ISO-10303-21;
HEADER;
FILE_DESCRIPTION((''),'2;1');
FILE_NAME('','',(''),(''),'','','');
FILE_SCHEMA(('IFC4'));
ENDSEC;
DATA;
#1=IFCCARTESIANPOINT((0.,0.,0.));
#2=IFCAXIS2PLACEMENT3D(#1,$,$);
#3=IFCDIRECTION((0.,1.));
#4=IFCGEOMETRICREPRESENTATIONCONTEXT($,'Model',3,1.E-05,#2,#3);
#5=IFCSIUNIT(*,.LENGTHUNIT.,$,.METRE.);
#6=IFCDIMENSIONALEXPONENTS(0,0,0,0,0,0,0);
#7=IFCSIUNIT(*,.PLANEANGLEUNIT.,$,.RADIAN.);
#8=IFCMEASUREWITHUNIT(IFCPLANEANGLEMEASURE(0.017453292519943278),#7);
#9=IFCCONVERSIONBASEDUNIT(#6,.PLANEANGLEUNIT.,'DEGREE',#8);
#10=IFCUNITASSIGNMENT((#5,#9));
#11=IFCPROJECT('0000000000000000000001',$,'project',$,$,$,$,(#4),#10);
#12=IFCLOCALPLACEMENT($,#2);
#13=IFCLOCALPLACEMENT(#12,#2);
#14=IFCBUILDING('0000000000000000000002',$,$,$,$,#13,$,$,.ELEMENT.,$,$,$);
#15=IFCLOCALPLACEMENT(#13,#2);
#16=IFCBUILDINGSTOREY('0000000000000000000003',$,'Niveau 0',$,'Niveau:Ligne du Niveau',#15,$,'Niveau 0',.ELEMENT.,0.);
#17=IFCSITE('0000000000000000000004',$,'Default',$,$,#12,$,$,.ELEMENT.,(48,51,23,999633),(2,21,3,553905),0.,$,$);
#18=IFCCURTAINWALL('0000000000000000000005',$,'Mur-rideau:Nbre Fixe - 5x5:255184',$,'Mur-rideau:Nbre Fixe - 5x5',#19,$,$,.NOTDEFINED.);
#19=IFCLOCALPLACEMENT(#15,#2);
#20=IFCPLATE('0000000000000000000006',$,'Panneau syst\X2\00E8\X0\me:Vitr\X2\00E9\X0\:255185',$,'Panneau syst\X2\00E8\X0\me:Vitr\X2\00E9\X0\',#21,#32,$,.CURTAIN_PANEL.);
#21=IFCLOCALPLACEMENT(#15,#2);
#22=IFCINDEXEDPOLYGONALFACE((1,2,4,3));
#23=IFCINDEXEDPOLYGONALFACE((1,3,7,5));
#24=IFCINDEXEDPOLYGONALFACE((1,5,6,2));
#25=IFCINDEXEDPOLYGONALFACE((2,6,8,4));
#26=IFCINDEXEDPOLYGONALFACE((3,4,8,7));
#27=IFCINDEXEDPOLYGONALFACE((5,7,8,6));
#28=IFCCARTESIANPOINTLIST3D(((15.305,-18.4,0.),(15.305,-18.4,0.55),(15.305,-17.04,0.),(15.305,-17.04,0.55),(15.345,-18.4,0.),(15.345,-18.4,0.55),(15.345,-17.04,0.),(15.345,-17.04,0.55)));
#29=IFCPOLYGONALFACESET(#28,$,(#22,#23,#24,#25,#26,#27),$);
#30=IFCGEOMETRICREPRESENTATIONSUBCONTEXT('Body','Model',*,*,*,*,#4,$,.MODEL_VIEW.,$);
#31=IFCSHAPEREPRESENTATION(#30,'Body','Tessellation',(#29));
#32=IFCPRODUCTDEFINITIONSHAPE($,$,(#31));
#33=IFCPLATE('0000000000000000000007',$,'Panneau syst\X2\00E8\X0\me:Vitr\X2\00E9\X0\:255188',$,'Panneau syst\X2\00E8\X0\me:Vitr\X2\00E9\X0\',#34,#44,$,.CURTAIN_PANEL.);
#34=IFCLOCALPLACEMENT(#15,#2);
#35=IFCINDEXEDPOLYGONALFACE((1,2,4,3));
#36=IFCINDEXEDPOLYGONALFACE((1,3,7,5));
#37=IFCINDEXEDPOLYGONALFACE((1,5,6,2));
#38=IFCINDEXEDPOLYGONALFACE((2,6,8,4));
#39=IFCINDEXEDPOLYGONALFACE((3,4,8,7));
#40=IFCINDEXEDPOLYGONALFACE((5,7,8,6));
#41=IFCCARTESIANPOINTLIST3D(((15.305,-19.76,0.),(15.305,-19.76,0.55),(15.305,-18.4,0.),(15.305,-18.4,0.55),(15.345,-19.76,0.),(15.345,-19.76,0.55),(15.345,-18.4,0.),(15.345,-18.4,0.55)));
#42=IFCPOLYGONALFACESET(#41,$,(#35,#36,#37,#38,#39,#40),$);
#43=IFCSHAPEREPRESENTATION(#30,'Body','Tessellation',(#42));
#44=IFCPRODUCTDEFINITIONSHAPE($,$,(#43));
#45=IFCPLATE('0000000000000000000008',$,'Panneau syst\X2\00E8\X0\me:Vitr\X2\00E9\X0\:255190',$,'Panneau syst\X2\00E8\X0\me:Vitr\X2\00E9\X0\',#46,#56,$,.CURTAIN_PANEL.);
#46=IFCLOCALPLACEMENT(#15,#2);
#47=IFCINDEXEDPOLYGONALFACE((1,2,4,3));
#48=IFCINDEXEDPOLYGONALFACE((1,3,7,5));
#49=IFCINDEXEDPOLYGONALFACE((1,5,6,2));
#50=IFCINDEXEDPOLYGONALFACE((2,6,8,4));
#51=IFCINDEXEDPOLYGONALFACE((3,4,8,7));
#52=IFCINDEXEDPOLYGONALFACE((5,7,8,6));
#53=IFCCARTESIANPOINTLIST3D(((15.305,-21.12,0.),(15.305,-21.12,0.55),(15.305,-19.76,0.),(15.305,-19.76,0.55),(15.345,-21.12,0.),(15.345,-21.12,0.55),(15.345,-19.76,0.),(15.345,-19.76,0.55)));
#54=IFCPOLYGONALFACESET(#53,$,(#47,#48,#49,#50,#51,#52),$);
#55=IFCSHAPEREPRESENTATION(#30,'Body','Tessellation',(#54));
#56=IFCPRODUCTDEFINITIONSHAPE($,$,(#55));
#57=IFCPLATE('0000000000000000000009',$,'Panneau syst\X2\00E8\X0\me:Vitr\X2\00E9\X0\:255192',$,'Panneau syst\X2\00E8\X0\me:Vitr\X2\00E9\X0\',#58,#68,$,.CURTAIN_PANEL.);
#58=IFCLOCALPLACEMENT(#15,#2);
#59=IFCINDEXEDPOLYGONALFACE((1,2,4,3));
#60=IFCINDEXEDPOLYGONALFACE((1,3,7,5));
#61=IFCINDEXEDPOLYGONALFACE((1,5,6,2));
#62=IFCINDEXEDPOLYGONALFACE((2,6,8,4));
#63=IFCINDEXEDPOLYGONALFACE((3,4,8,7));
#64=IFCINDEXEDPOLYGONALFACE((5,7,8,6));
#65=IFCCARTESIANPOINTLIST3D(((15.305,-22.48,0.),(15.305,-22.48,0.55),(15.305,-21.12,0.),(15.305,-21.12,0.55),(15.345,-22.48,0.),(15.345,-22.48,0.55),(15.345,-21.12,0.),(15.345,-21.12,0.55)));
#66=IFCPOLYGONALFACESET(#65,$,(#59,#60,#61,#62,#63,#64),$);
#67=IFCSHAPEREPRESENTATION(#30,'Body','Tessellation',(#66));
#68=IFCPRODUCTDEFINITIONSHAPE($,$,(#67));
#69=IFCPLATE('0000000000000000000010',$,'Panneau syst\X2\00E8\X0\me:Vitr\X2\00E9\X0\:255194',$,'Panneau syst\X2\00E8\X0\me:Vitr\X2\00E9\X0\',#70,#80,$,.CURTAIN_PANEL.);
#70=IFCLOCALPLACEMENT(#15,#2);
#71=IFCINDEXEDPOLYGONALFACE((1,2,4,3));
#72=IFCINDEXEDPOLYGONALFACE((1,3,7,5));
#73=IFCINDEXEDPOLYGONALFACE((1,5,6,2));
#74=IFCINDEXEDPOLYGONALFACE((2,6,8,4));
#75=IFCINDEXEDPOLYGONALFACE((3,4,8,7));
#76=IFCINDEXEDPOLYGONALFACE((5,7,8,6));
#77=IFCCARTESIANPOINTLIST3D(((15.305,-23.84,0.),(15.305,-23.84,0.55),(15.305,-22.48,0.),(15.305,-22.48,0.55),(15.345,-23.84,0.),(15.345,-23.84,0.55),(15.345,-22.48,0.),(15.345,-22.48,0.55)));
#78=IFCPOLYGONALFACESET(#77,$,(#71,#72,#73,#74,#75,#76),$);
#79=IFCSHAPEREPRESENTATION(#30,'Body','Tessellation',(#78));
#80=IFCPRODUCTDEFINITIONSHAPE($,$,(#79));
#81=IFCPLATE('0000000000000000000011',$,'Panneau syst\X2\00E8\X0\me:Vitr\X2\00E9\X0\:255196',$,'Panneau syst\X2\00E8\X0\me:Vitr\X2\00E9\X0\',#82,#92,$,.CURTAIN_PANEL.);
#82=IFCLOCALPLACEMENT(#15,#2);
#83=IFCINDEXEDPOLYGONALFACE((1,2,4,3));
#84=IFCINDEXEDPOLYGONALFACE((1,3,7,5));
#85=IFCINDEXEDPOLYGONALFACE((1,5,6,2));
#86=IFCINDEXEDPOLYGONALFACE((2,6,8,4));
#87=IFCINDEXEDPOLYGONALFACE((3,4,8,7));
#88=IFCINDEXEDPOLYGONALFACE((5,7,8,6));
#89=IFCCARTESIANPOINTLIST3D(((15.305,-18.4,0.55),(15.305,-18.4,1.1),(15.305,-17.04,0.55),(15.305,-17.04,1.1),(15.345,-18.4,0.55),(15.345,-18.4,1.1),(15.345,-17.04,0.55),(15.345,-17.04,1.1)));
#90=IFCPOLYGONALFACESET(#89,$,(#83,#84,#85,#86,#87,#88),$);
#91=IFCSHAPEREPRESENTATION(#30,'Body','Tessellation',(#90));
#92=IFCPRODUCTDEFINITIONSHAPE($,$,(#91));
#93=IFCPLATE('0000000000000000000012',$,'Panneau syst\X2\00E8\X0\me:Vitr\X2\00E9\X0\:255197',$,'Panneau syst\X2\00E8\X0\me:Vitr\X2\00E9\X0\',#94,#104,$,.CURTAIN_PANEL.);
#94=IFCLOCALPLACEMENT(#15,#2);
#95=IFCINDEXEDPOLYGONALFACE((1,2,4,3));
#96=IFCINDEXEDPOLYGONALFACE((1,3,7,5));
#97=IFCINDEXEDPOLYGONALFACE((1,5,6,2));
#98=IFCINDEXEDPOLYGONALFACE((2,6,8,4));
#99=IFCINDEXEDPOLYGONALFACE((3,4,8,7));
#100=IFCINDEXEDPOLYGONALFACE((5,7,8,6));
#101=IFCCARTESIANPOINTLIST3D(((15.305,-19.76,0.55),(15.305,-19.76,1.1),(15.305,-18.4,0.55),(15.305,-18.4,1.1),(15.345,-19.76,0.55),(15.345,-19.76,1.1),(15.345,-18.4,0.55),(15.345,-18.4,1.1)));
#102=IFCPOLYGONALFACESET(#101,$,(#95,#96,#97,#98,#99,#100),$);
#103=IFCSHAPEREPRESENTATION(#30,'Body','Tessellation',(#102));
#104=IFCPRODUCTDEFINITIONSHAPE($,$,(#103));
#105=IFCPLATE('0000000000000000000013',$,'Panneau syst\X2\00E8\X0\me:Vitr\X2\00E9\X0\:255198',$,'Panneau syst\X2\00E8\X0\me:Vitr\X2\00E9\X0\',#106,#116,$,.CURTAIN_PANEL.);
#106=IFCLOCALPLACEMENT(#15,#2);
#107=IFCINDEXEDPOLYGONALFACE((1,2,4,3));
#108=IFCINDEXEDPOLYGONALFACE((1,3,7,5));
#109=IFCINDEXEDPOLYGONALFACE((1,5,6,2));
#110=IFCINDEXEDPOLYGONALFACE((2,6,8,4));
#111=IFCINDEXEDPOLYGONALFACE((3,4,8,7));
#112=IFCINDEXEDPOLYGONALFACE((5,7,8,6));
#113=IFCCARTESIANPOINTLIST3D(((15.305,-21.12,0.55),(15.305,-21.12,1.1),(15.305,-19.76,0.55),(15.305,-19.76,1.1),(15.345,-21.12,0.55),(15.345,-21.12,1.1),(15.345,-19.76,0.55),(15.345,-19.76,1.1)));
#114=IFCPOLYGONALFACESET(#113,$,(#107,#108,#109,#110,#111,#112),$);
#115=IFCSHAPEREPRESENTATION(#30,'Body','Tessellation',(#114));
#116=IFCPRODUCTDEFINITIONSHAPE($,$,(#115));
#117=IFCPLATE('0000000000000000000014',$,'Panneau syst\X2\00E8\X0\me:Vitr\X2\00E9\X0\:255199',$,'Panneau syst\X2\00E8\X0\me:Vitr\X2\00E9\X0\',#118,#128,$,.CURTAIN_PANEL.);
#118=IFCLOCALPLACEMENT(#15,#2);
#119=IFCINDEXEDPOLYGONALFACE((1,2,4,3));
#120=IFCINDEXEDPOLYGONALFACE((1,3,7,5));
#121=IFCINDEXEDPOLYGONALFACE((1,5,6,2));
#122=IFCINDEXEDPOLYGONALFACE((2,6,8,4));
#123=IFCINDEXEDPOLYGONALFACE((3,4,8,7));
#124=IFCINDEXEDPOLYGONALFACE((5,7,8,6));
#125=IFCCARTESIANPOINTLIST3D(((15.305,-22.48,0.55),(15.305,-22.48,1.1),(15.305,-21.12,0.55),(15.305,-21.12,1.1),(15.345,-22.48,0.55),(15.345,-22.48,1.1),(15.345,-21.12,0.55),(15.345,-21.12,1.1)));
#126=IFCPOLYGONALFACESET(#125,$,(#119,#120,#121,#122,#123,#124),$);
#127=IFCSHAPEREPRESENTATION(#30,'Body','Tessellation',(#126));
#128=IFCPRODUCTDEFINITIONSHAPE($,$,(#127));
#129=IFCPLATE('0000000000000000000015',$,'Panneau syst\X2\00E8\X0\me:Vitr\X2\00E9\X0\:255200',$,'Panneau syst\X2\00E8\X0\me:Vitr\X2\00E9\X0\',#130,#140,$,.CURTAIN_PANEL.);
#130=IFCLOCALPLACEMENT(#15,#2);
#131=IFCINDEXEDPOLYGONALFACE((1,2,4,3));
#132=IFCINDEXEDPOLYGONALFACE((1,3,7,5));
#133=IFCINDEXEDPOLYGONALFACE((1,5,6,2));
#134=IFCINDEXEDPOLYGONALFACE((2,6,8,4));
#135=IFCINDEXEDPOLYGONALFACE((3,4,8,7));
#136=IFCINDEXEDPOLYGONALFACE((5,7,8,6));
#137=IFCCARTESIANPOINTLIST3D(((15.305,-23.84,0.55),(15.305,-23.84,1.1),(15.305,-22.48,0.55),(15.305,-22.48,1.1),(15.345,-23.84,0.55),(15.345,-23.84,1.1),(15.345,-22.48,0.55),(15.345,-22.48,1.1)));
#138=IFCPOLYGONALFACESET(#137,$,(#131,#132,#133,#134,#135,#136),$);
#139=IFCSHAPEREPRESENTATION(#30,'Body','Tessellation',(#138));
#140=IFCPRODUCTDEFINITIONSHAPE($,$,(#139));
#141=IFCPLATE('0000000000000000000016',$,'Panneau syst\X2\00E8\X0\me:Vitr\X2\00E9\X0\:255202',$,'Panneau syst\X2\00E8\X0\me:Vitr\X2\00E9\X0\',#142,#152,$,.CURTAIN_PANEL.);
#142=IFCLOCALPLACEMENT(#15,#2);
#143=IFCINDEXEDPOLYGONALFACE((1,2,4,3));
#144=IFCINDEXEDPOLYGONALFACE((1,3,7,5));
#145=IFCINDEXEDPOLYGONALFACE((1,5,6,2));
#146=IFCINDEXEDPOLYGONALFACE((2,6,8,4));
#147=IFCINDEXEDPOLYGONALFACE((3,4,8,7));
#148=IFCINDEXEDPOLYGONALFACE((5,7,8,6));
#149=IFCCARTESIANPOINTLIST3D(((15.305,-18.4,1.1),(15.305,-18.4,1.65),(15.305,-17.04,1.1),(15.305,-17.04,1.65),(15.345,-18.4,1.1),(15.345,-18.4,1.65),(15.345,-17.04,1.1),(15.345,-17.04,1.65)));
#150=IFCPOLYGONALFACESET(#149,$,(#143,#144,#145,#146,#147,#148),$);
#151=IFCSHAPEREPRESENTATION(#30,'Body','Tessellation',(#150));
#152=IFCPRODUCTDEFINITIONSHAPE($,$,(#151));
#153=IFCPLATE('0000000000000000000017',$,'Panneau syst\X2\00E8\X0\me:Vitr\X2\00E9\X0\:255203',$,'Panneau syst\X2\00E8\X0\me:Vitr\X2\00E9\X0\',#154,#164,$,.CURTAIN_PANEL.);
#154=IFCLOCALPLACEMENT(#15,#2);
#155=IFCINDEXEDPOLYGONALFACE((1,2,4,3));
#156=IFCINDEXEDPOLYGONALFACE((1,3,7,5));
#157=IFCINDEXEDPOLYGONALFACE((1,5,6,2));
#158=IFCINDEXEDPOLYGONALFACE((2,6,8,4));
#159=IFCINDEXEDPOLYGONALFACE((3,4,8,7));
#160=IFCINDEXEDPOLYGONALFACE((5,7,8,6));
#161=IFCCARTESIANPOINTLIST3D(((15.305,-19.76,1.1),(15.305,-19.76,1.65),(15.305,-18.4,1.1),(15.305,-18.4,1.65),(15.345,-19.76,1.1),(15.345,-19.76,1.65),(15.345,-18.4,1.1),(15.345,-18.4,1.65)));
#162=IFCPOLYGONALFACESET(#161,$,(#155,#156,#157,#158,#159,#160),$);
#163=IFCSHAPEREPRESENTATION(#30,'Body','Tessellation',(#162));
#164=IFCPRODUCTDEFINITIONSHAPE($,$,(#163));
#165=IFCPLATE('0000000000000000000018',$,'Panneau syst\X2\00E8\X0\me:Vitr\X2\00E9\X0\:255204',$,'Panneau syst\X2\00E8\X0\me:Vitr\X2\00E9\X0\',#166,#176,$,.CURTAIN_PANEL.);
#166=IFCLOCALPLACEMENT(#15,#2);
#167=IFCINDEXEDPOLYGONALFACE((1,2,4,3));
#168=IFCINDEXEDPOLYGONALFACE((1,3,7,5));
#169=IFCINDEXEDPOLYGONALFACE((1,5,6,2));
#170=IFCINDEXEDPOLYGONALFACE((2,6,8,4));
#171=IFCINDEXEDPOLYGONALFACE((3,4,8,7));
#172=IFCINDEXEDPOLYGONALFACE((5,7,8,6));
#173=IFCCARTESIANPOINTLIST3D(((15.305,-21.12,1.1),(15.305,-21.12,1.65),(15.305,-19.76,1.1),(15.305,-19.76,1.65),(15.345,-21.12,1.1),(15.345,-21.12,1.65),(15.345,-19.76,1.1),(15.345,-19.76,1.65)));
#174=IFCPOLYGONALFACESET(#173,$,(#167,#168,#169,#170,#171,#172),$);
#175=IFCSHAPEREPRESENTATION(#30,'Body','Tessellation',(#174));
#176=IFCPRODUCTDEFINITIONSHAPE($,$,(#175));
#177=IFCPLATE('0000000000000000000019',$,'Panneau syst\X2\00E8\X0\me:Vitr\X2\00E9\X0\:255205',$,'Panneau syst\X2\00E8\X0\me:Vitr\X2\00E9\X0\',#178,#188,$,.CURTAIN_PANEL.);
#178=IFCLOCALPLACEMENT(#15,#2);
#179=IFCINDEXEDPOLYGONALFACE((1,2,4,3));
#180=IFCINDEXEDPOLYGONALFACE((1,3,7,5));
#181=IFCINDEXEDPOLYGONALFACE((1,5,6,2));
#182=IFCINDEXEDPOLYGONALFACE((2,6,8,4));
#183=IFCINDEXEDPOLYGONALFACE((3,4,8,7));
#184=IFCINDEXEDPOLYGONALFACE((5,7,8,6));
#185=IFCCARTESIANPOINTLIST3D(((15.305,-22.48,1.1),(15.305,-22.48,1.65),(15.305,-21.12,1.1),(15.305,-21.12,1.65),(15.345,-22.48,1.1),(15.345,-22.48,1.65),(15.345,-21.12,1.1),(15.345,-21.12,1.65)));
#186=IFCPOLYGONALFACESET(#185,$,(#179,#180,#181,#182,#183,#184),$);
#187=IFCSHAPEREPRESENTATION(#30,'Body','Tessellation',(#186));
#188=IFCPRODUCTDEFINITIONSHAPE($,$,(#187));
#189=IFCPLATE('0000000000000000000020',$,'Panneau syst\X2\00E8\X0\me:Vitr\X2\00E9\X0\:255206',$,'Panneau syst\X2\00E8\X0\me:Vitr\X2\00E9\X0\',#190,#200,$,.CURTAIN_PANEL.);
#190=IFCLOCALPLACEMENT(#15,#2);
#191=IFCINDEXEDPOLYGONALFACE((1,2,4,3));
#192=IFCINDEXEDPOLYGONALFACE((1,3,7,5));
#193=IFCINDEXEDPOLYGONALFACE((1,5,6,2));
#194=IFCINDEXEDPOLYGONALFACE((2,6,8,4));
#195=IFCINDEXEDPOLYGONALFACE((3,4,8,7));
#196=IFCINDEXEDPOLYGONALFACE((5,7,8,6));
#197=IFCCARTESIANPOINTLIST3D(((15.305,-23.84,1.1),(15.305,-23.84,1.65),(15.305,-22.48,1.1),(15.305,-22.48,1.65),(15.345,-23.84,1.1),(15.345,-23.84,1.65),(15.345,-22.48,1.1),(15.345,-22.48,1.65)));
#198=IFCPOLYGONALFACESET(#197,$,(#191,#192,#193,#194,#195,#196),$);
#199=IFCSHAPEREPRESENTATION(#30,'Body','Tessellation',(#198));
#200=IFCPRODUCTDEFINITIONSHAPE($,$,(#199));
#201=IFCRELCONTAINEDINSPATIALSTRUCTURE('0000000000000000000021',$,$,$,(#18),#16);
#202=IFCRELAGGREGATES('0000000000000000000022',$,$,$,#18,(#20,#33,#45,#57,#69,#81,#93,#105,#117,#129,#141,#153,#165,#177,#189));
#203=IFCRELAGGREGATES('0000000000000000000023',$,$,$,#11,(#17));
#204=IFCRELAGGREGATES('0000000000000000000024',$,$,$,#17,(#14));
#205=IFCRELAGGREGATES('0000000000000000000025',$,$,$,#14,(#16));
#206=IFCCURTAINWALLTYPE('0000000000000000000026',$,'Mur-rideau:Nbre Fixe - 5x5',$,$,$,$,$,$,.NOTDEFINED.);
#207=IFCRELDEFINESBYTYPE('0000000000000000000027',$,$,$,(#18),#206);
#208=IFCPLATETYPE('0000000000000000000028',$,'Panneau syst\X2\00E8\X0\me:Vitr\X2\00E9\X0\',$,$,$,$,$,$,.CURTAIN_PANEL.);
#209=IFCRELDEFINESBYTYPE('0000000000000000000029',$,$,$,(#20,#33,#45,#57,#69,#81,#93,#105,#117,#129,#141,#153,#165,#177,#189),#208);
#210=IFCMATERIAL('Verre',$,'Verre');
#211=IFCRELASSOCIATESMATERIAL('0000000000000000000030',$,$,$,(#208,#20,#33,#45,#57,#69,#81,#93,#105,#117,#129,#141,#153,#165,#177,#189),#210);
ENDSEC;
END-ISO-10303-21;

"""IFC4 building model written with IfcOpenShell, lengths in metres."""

from ifc_helpers import new_model, entity, si_unit, converted_unit, direction, frame, origin, place, context, subcontext, project, spatial, indexed_curve, outline, extrude, source, transform, mapped, material, type_object, type_shapes, element, aggregate, save


model = new_model("IFC4")

# Units and contexts
model_context = context("Model", 3, precision=1e-05, world=origin(), true_north=direction((0.0, 1.0)))
body_context = subcontext(model_context, "Body", "Model", "MODEL_VIEW")
ifc_project = project(units=[si_unit("LENGTHUNIT", "METRE"), converted_unit("PLANEANGLEUNIT", "DEGREE", entity("IfcPlaneAngleMeasure", 0.017453292519943278), si_unit("PLANEANGLEUNIT", "RADIAN"), dimensions=[0, 0, 0, 0, 0, 0, 0])], contexts=[model_context])

# Site, building, storey
site_placement = place(None, origin())
site = spatial("IfcSite", under=ifc_project, at=site_placement, Name="Default", CompositionType="ELEMENT", RefLatitude=(48, 51, 23, 999633), RefLongitude=(2, 21, 3, 553905), RefElevation=0.0)
building_placement = place(site_placement, origin())
building = spatial("IfcBuilding", under=site, at=building_placement, CompositionType="ELEMENT")
storey_placement = place(building_placement, origin())
storey = spatial("IfcBuildingStorey", under=building, at=storey_placement, Name="Niveau 0", ObjectType="Niveau:Ligne du Niveau", LongName="Niveau 0", CompositionType="ELEMENT", Elevation=0.0)

# Curtain wall, plates
curtain_wall_type = type_object("IfcCurtainWallType", Name="Mur-rideau:Nbre Fixe - 5x5", PredefinedType="NOTDEFINED")
curtain_wall_placement = place(storey_placement, origin())
curtain_wall = element("IfcCurtainWall", 1, at=curtain_wall_placement, inside=storey, type_object=curtain_wall_type, Name="Mur-rideau:Nbre Fixe - 5x5:255184", ObjectType="Mur-rideau:Nbre Fixe - 5x5", PredefinedType="NOTDEFINED")
ifc_material = material(Name="Verre", Category="Verre")
plate_type = type_object("IfcPlateType", Name="Panneau système:Vitré", PredefinedType="CURTAIN_PANEL", material=ifc_material)
shared_shape = source(origin(), body_context, "Body", "SweptSolid", [
    extrude(outline(indexed_curve([(-0.02, -0.68), (0.02, -0.68), (0.02, 0.68), (-0.02, 0.68), (-0.02, -0.68)], self_intersect=False)), frame((0.68, 0.02, 0.0), z_axis=(0.0, 0.0, 1.0), x_axis=(0.0, 1.0, 0.0)), (0.0, 0.0, 1.0), 0.55),
])
type_shapes(plate_type, [shared_shape])
plate_1_placement = place(curtain_wall_placement, frame((15.305, -17.04, 0.0), z_axis=(0.0, 0.0, 1.0), x_axis=(0.0, -1.0, 0.0)))
plate_1 = element("IfcPlate", 2, at=plate_1_placement, type_object=plate_type, material=ifc_material, Name="Panneau système:Vitré:255185", ObjectType="Panneau système:Vitré", PredefinedType="CURTAIN_PANEL", context=body_context, shape_type="MappedRepresentation", body=[
    mapped(shared_shape, transform((0.0, 0.0, 0.0), scale=1.0)),
])
plate_2_placement = place(curtain_wall_placement, frame((15.305, -18.4, 0.0), z_axis=(0.0, 0.0, 1.0), x_axis=(0.0, -1.0, 0.0)))
plate_2 = element("IfcPlate", 3, at=plate_2_placement, type_object=plate_type, material=ifc_material, Name="Panneau système:Vitré:255188", ObjectType="Panneau système:Vitré", PredefinedType="CURTAIN_PANEL", context=body_context, shape_type="MappedRepresentation", body=[
    mapped(shared_shape, transform((0.0, 0.0, 0.0), scale=1.0)),
])
plate_3_placement = place(curtain_wall_placement, frame((15.305, -19.76, 0.0), z_axis=(0.0, 0.0, 1.0), x_axis=(0.0, -1.0, 0.0)))
plate_3 = element("IfcPlate", 4, at=plate_3_placement, type_object=plate_type, material=ifc_material, Name="Panneau système:Vitré:255190", ObjectType="Panneau système:Vitré", PredefinedType="CURTAIN_PANEL", context=body_context, shape_type="MappedRepresentation", body=[
    mapped(shared_shape, transform((0.0, 0.0, 0.0), scale=1.0)),
])
plate_4_placement = place(curtain_wall_placement, frame((15.305, -21.12, 0.0), z_axis=(0.0, 0.0, 1.0), x_axis=(0.0, -1.0, 0.0)))
plate_4 = element("IfcPlate", 5, at=plate_4_placement, type_object=plate_type, material=ifc_material, Name="Panneau système:Vitré:255192", ObjectType="Panneau système:Vitré", PredefinedType="CURTAIN_PANEL", context=body_context, shape_type="MappedRepresentation", body=[
    mapped(shared_shape, transform((0.0, 0.0, 0.0), scale=1.0)),
])
plate_5_placement = place(curtain_wall_placement, frame((15.305, -22.48, 0.0), z_axis=(0.0, 0.0, 1.0), x_axis=(0.0, -1.0, 0.0)))
plate_5 = element("IfcPlate", 6, at=plate_5_placement, type_object=plate_type, material=ifc_material, Name="Panneau système:Vitré:255194", ObjectType="Panneau système:Vitré", PredefinedType="CURTAIN_PANEL", context=body_context, shape_type="MappedRepresentation", body=[
    mapped(shared_shape, transform((0.0, 0.0, 0.0), scale=1.0)),
])
plate_6_placement = place(curtain_wall_placement, frame((15.305, -17.04, 0.55), z_axis=(0.0, 0.0, 1.0), x_axis=(0.0, -1.0, 0.0)))
plate_6 = element("IfcPlate", 7, at=plate_6_placement, type_object=plate_type, material=ifc_material, Name="Panneau système:Vitré:255196", ObjectType="Panneau système:Vitré", PredefinedType="CURTAIN_PANEL", context=body_context, shape_type="MappedRepresentation", body=[
    mapped(shared_shape, transform((0.0, 0.0, 0.0), scale=1.0)),
])
plate_7_placement = place(curtain_wall_placement, frame((15.305, -18.4, 0.55), z_axis=(0.0, 0.0, 1.0), x_axis=(0.0, -1.0, 0.0)))
plate_7 = element("IfcPlate", 8, at=plate_7_placement, type_object=plate_type, material=ifc_material, Name="Panneau système:Vitré:255197", ObjectType="Panneau système:Vitré", PredefinedType="CURTAIN_PANEL", context=body_context, shape_type="MappedRepresentation", body=[
    mapped(shared_shape, transform((0.0, 0.0, 0.0), scale=1.0)),
])
plate_8_placement = place(curtain_wall_placement, frame((15.305, -19.76, 0.55), z_axis=(0.0, 0.0, 1.0), x_axis=(0.0, -1.0, 0.0)))
plate_8 = element("IfcPlate", 9, at=plate_8_placement, type_object=plate_type, material=ifc_material, Name="Panneau système:Vitré:255198", ObjectType="Panneau système:Vitré", PredefinedType="CURTAIN_PANEL", context=body_context, shape_type="MappedRepresentation", body=[
    mapped(shared_shape, transform((0.0, 0.0, 0.0), scale=1.0)),
])
plate_9_placement = place(curtain_wall_placement, frame((15.305, -21.12, 0.55), z_axis=(0.0, 0.0, 1.0), x_axis=(0.0, -1.0, 0.0)))
plate_9 = element("IfcPlate", 10, at=plate_9_placement, type_object=plate_type, material=ifc_material, Name="Panneau système:Vitré:255199", ObjectType="Panneau système:Vitré", PredefinedType="CURTAIN_PANEL", context=body_context, shape_type="MappedRepresentation", body=[
    mapped(shared_shape, transform((0.0, 0.0, 0.0), scale=1.0)),
])
plate_10_placement = place(curtain_wall_placement, frame((15.305, -22.48, 0.55), z_axis=(0.0, 0.0, 1.0), x_axis=(0.0, -1.0, 0.0)))
plate_10 = element("IfcPlate", 11, at=plate_10_placement, type_object=plate_type, material=ifc_material, Name="Panneau système:Vitré:255200", ObjectType="Panneau système:Vitré", PredefinedType="CURTAIN_PANEL", context=body_context, shape_type="MappedRepresentation", body=[
    mapped(shared_shape, transform((0.0, 0.0, 0.0), scale=1.0)),
])
plate_11_placement = place(curtain_wall_placement, frame((15.305, -17.04, 1.1), z_axis=(0.0, 0.0, 1.0), x_axis=(0.0, -1.0, 0.0)))
plate_11 = element("IfcPlate", 12, at=plate_11_placement, type_object=plate_type, material=ifc_material, Name="Panneau système:Vitré:255202", ObjectType="Panneau système:Vitré", PredefinedType="CURTAIN_PANEL", context=body_context, shape_type="MappedRepresentation", body=[
    mapped(shared_shape, transform((0.0, 0.0, 0.0), scale=1.0)),
])
plate_12_placement = place(curtain_wall_placement, frame((15.305, -18.4, 1.1), z_axis=(0.0, 0.0, 1.0), x_axis=(0.0, -1.0, 0.0)))
plate_12 = element("IfcPlate", 13, at=plate_12_placement, type_object=plate_type, material=ifc_material, Name="Panneau système:Vitré:255203", ObjectType="Panneau système:Vitré", PredefinedType="CURTAIN_PANEL", context=body_context, shape_type="MappedRepresentation", body=[
    mapped(shared_shape, transform((0.0, 0.0, 0.0), scale=1.0)),
])
plate_13_placement = place(curtain_wall_placement, frame((15.305, -19.76, 1.1), z_axis=(0.0, 0.0, 1.0), x_axis=(0.0, -1.0, 0.0)))
plate_13 = element("IfcPlate", 14, at=plate_13_placement, type_object=plate_type, material=ifc_material, Name="Panneau système:Vitré:255204", ObjectType="Panneau système:Vitré", PredefinedType="CURTAIN_PANEL", context=body_context, shape_type="MappedRepresentation", body=[
    mapped(shared_shape, transform((0.0, 0.0, 0.0), scale=1.0)),
])
plate_14_placement = place(curtain_wall_placement, frame((15.305, -21.12, 1.1), z_axis=(0.0, 0.0, 1.0), x_axis=(0.0, -1.0, 0.0)))
plate_14 = element("IfcPlate", 15, at=plate_14_placement, type_object=plate_type, material=ifc_material, Name="Panneau système:Vitré:255205", ObjectType="Panneau système:Vitré", PredefinedType="CURTAIN_PANEL", context=body_context, shape_type="MappedRepresentation", body=[
    mapped(shared_shape, transform((0.0, 0.0, 0.0), scale=1.0)),
])
plate_15_placement = place(curtain_wall_placement, frame((15.305, -22.48, 1.1), z_axis=(0.0, 0.0, 1.0), x_axis=(0.0, -1.0, 0.0)))
plate_15 = element("IfcPlate", 16, at=plate_15_placement, type_object=plate_type, material=ifc_material, Name="Panneau système:Vitré:255206", ObjectType="Panneau système:Vitré", PredefinedType="CURTAIN_PANEL", context=body_context, shape_type="MappedRepresentation", body=[
    mapped(shared_shape, transform((0.0, 0.0, 0.0), scale=1.0)),
])
aggregate(curtain_wall, [plate_1, plate_2, plate_3, plate_4, plate_5, plate_6, plate_7, plate_8, plate_9, plate_10, plate_11, plate_12, plate_13, plate_14, plate_15])

save(model, "model.ifc")
